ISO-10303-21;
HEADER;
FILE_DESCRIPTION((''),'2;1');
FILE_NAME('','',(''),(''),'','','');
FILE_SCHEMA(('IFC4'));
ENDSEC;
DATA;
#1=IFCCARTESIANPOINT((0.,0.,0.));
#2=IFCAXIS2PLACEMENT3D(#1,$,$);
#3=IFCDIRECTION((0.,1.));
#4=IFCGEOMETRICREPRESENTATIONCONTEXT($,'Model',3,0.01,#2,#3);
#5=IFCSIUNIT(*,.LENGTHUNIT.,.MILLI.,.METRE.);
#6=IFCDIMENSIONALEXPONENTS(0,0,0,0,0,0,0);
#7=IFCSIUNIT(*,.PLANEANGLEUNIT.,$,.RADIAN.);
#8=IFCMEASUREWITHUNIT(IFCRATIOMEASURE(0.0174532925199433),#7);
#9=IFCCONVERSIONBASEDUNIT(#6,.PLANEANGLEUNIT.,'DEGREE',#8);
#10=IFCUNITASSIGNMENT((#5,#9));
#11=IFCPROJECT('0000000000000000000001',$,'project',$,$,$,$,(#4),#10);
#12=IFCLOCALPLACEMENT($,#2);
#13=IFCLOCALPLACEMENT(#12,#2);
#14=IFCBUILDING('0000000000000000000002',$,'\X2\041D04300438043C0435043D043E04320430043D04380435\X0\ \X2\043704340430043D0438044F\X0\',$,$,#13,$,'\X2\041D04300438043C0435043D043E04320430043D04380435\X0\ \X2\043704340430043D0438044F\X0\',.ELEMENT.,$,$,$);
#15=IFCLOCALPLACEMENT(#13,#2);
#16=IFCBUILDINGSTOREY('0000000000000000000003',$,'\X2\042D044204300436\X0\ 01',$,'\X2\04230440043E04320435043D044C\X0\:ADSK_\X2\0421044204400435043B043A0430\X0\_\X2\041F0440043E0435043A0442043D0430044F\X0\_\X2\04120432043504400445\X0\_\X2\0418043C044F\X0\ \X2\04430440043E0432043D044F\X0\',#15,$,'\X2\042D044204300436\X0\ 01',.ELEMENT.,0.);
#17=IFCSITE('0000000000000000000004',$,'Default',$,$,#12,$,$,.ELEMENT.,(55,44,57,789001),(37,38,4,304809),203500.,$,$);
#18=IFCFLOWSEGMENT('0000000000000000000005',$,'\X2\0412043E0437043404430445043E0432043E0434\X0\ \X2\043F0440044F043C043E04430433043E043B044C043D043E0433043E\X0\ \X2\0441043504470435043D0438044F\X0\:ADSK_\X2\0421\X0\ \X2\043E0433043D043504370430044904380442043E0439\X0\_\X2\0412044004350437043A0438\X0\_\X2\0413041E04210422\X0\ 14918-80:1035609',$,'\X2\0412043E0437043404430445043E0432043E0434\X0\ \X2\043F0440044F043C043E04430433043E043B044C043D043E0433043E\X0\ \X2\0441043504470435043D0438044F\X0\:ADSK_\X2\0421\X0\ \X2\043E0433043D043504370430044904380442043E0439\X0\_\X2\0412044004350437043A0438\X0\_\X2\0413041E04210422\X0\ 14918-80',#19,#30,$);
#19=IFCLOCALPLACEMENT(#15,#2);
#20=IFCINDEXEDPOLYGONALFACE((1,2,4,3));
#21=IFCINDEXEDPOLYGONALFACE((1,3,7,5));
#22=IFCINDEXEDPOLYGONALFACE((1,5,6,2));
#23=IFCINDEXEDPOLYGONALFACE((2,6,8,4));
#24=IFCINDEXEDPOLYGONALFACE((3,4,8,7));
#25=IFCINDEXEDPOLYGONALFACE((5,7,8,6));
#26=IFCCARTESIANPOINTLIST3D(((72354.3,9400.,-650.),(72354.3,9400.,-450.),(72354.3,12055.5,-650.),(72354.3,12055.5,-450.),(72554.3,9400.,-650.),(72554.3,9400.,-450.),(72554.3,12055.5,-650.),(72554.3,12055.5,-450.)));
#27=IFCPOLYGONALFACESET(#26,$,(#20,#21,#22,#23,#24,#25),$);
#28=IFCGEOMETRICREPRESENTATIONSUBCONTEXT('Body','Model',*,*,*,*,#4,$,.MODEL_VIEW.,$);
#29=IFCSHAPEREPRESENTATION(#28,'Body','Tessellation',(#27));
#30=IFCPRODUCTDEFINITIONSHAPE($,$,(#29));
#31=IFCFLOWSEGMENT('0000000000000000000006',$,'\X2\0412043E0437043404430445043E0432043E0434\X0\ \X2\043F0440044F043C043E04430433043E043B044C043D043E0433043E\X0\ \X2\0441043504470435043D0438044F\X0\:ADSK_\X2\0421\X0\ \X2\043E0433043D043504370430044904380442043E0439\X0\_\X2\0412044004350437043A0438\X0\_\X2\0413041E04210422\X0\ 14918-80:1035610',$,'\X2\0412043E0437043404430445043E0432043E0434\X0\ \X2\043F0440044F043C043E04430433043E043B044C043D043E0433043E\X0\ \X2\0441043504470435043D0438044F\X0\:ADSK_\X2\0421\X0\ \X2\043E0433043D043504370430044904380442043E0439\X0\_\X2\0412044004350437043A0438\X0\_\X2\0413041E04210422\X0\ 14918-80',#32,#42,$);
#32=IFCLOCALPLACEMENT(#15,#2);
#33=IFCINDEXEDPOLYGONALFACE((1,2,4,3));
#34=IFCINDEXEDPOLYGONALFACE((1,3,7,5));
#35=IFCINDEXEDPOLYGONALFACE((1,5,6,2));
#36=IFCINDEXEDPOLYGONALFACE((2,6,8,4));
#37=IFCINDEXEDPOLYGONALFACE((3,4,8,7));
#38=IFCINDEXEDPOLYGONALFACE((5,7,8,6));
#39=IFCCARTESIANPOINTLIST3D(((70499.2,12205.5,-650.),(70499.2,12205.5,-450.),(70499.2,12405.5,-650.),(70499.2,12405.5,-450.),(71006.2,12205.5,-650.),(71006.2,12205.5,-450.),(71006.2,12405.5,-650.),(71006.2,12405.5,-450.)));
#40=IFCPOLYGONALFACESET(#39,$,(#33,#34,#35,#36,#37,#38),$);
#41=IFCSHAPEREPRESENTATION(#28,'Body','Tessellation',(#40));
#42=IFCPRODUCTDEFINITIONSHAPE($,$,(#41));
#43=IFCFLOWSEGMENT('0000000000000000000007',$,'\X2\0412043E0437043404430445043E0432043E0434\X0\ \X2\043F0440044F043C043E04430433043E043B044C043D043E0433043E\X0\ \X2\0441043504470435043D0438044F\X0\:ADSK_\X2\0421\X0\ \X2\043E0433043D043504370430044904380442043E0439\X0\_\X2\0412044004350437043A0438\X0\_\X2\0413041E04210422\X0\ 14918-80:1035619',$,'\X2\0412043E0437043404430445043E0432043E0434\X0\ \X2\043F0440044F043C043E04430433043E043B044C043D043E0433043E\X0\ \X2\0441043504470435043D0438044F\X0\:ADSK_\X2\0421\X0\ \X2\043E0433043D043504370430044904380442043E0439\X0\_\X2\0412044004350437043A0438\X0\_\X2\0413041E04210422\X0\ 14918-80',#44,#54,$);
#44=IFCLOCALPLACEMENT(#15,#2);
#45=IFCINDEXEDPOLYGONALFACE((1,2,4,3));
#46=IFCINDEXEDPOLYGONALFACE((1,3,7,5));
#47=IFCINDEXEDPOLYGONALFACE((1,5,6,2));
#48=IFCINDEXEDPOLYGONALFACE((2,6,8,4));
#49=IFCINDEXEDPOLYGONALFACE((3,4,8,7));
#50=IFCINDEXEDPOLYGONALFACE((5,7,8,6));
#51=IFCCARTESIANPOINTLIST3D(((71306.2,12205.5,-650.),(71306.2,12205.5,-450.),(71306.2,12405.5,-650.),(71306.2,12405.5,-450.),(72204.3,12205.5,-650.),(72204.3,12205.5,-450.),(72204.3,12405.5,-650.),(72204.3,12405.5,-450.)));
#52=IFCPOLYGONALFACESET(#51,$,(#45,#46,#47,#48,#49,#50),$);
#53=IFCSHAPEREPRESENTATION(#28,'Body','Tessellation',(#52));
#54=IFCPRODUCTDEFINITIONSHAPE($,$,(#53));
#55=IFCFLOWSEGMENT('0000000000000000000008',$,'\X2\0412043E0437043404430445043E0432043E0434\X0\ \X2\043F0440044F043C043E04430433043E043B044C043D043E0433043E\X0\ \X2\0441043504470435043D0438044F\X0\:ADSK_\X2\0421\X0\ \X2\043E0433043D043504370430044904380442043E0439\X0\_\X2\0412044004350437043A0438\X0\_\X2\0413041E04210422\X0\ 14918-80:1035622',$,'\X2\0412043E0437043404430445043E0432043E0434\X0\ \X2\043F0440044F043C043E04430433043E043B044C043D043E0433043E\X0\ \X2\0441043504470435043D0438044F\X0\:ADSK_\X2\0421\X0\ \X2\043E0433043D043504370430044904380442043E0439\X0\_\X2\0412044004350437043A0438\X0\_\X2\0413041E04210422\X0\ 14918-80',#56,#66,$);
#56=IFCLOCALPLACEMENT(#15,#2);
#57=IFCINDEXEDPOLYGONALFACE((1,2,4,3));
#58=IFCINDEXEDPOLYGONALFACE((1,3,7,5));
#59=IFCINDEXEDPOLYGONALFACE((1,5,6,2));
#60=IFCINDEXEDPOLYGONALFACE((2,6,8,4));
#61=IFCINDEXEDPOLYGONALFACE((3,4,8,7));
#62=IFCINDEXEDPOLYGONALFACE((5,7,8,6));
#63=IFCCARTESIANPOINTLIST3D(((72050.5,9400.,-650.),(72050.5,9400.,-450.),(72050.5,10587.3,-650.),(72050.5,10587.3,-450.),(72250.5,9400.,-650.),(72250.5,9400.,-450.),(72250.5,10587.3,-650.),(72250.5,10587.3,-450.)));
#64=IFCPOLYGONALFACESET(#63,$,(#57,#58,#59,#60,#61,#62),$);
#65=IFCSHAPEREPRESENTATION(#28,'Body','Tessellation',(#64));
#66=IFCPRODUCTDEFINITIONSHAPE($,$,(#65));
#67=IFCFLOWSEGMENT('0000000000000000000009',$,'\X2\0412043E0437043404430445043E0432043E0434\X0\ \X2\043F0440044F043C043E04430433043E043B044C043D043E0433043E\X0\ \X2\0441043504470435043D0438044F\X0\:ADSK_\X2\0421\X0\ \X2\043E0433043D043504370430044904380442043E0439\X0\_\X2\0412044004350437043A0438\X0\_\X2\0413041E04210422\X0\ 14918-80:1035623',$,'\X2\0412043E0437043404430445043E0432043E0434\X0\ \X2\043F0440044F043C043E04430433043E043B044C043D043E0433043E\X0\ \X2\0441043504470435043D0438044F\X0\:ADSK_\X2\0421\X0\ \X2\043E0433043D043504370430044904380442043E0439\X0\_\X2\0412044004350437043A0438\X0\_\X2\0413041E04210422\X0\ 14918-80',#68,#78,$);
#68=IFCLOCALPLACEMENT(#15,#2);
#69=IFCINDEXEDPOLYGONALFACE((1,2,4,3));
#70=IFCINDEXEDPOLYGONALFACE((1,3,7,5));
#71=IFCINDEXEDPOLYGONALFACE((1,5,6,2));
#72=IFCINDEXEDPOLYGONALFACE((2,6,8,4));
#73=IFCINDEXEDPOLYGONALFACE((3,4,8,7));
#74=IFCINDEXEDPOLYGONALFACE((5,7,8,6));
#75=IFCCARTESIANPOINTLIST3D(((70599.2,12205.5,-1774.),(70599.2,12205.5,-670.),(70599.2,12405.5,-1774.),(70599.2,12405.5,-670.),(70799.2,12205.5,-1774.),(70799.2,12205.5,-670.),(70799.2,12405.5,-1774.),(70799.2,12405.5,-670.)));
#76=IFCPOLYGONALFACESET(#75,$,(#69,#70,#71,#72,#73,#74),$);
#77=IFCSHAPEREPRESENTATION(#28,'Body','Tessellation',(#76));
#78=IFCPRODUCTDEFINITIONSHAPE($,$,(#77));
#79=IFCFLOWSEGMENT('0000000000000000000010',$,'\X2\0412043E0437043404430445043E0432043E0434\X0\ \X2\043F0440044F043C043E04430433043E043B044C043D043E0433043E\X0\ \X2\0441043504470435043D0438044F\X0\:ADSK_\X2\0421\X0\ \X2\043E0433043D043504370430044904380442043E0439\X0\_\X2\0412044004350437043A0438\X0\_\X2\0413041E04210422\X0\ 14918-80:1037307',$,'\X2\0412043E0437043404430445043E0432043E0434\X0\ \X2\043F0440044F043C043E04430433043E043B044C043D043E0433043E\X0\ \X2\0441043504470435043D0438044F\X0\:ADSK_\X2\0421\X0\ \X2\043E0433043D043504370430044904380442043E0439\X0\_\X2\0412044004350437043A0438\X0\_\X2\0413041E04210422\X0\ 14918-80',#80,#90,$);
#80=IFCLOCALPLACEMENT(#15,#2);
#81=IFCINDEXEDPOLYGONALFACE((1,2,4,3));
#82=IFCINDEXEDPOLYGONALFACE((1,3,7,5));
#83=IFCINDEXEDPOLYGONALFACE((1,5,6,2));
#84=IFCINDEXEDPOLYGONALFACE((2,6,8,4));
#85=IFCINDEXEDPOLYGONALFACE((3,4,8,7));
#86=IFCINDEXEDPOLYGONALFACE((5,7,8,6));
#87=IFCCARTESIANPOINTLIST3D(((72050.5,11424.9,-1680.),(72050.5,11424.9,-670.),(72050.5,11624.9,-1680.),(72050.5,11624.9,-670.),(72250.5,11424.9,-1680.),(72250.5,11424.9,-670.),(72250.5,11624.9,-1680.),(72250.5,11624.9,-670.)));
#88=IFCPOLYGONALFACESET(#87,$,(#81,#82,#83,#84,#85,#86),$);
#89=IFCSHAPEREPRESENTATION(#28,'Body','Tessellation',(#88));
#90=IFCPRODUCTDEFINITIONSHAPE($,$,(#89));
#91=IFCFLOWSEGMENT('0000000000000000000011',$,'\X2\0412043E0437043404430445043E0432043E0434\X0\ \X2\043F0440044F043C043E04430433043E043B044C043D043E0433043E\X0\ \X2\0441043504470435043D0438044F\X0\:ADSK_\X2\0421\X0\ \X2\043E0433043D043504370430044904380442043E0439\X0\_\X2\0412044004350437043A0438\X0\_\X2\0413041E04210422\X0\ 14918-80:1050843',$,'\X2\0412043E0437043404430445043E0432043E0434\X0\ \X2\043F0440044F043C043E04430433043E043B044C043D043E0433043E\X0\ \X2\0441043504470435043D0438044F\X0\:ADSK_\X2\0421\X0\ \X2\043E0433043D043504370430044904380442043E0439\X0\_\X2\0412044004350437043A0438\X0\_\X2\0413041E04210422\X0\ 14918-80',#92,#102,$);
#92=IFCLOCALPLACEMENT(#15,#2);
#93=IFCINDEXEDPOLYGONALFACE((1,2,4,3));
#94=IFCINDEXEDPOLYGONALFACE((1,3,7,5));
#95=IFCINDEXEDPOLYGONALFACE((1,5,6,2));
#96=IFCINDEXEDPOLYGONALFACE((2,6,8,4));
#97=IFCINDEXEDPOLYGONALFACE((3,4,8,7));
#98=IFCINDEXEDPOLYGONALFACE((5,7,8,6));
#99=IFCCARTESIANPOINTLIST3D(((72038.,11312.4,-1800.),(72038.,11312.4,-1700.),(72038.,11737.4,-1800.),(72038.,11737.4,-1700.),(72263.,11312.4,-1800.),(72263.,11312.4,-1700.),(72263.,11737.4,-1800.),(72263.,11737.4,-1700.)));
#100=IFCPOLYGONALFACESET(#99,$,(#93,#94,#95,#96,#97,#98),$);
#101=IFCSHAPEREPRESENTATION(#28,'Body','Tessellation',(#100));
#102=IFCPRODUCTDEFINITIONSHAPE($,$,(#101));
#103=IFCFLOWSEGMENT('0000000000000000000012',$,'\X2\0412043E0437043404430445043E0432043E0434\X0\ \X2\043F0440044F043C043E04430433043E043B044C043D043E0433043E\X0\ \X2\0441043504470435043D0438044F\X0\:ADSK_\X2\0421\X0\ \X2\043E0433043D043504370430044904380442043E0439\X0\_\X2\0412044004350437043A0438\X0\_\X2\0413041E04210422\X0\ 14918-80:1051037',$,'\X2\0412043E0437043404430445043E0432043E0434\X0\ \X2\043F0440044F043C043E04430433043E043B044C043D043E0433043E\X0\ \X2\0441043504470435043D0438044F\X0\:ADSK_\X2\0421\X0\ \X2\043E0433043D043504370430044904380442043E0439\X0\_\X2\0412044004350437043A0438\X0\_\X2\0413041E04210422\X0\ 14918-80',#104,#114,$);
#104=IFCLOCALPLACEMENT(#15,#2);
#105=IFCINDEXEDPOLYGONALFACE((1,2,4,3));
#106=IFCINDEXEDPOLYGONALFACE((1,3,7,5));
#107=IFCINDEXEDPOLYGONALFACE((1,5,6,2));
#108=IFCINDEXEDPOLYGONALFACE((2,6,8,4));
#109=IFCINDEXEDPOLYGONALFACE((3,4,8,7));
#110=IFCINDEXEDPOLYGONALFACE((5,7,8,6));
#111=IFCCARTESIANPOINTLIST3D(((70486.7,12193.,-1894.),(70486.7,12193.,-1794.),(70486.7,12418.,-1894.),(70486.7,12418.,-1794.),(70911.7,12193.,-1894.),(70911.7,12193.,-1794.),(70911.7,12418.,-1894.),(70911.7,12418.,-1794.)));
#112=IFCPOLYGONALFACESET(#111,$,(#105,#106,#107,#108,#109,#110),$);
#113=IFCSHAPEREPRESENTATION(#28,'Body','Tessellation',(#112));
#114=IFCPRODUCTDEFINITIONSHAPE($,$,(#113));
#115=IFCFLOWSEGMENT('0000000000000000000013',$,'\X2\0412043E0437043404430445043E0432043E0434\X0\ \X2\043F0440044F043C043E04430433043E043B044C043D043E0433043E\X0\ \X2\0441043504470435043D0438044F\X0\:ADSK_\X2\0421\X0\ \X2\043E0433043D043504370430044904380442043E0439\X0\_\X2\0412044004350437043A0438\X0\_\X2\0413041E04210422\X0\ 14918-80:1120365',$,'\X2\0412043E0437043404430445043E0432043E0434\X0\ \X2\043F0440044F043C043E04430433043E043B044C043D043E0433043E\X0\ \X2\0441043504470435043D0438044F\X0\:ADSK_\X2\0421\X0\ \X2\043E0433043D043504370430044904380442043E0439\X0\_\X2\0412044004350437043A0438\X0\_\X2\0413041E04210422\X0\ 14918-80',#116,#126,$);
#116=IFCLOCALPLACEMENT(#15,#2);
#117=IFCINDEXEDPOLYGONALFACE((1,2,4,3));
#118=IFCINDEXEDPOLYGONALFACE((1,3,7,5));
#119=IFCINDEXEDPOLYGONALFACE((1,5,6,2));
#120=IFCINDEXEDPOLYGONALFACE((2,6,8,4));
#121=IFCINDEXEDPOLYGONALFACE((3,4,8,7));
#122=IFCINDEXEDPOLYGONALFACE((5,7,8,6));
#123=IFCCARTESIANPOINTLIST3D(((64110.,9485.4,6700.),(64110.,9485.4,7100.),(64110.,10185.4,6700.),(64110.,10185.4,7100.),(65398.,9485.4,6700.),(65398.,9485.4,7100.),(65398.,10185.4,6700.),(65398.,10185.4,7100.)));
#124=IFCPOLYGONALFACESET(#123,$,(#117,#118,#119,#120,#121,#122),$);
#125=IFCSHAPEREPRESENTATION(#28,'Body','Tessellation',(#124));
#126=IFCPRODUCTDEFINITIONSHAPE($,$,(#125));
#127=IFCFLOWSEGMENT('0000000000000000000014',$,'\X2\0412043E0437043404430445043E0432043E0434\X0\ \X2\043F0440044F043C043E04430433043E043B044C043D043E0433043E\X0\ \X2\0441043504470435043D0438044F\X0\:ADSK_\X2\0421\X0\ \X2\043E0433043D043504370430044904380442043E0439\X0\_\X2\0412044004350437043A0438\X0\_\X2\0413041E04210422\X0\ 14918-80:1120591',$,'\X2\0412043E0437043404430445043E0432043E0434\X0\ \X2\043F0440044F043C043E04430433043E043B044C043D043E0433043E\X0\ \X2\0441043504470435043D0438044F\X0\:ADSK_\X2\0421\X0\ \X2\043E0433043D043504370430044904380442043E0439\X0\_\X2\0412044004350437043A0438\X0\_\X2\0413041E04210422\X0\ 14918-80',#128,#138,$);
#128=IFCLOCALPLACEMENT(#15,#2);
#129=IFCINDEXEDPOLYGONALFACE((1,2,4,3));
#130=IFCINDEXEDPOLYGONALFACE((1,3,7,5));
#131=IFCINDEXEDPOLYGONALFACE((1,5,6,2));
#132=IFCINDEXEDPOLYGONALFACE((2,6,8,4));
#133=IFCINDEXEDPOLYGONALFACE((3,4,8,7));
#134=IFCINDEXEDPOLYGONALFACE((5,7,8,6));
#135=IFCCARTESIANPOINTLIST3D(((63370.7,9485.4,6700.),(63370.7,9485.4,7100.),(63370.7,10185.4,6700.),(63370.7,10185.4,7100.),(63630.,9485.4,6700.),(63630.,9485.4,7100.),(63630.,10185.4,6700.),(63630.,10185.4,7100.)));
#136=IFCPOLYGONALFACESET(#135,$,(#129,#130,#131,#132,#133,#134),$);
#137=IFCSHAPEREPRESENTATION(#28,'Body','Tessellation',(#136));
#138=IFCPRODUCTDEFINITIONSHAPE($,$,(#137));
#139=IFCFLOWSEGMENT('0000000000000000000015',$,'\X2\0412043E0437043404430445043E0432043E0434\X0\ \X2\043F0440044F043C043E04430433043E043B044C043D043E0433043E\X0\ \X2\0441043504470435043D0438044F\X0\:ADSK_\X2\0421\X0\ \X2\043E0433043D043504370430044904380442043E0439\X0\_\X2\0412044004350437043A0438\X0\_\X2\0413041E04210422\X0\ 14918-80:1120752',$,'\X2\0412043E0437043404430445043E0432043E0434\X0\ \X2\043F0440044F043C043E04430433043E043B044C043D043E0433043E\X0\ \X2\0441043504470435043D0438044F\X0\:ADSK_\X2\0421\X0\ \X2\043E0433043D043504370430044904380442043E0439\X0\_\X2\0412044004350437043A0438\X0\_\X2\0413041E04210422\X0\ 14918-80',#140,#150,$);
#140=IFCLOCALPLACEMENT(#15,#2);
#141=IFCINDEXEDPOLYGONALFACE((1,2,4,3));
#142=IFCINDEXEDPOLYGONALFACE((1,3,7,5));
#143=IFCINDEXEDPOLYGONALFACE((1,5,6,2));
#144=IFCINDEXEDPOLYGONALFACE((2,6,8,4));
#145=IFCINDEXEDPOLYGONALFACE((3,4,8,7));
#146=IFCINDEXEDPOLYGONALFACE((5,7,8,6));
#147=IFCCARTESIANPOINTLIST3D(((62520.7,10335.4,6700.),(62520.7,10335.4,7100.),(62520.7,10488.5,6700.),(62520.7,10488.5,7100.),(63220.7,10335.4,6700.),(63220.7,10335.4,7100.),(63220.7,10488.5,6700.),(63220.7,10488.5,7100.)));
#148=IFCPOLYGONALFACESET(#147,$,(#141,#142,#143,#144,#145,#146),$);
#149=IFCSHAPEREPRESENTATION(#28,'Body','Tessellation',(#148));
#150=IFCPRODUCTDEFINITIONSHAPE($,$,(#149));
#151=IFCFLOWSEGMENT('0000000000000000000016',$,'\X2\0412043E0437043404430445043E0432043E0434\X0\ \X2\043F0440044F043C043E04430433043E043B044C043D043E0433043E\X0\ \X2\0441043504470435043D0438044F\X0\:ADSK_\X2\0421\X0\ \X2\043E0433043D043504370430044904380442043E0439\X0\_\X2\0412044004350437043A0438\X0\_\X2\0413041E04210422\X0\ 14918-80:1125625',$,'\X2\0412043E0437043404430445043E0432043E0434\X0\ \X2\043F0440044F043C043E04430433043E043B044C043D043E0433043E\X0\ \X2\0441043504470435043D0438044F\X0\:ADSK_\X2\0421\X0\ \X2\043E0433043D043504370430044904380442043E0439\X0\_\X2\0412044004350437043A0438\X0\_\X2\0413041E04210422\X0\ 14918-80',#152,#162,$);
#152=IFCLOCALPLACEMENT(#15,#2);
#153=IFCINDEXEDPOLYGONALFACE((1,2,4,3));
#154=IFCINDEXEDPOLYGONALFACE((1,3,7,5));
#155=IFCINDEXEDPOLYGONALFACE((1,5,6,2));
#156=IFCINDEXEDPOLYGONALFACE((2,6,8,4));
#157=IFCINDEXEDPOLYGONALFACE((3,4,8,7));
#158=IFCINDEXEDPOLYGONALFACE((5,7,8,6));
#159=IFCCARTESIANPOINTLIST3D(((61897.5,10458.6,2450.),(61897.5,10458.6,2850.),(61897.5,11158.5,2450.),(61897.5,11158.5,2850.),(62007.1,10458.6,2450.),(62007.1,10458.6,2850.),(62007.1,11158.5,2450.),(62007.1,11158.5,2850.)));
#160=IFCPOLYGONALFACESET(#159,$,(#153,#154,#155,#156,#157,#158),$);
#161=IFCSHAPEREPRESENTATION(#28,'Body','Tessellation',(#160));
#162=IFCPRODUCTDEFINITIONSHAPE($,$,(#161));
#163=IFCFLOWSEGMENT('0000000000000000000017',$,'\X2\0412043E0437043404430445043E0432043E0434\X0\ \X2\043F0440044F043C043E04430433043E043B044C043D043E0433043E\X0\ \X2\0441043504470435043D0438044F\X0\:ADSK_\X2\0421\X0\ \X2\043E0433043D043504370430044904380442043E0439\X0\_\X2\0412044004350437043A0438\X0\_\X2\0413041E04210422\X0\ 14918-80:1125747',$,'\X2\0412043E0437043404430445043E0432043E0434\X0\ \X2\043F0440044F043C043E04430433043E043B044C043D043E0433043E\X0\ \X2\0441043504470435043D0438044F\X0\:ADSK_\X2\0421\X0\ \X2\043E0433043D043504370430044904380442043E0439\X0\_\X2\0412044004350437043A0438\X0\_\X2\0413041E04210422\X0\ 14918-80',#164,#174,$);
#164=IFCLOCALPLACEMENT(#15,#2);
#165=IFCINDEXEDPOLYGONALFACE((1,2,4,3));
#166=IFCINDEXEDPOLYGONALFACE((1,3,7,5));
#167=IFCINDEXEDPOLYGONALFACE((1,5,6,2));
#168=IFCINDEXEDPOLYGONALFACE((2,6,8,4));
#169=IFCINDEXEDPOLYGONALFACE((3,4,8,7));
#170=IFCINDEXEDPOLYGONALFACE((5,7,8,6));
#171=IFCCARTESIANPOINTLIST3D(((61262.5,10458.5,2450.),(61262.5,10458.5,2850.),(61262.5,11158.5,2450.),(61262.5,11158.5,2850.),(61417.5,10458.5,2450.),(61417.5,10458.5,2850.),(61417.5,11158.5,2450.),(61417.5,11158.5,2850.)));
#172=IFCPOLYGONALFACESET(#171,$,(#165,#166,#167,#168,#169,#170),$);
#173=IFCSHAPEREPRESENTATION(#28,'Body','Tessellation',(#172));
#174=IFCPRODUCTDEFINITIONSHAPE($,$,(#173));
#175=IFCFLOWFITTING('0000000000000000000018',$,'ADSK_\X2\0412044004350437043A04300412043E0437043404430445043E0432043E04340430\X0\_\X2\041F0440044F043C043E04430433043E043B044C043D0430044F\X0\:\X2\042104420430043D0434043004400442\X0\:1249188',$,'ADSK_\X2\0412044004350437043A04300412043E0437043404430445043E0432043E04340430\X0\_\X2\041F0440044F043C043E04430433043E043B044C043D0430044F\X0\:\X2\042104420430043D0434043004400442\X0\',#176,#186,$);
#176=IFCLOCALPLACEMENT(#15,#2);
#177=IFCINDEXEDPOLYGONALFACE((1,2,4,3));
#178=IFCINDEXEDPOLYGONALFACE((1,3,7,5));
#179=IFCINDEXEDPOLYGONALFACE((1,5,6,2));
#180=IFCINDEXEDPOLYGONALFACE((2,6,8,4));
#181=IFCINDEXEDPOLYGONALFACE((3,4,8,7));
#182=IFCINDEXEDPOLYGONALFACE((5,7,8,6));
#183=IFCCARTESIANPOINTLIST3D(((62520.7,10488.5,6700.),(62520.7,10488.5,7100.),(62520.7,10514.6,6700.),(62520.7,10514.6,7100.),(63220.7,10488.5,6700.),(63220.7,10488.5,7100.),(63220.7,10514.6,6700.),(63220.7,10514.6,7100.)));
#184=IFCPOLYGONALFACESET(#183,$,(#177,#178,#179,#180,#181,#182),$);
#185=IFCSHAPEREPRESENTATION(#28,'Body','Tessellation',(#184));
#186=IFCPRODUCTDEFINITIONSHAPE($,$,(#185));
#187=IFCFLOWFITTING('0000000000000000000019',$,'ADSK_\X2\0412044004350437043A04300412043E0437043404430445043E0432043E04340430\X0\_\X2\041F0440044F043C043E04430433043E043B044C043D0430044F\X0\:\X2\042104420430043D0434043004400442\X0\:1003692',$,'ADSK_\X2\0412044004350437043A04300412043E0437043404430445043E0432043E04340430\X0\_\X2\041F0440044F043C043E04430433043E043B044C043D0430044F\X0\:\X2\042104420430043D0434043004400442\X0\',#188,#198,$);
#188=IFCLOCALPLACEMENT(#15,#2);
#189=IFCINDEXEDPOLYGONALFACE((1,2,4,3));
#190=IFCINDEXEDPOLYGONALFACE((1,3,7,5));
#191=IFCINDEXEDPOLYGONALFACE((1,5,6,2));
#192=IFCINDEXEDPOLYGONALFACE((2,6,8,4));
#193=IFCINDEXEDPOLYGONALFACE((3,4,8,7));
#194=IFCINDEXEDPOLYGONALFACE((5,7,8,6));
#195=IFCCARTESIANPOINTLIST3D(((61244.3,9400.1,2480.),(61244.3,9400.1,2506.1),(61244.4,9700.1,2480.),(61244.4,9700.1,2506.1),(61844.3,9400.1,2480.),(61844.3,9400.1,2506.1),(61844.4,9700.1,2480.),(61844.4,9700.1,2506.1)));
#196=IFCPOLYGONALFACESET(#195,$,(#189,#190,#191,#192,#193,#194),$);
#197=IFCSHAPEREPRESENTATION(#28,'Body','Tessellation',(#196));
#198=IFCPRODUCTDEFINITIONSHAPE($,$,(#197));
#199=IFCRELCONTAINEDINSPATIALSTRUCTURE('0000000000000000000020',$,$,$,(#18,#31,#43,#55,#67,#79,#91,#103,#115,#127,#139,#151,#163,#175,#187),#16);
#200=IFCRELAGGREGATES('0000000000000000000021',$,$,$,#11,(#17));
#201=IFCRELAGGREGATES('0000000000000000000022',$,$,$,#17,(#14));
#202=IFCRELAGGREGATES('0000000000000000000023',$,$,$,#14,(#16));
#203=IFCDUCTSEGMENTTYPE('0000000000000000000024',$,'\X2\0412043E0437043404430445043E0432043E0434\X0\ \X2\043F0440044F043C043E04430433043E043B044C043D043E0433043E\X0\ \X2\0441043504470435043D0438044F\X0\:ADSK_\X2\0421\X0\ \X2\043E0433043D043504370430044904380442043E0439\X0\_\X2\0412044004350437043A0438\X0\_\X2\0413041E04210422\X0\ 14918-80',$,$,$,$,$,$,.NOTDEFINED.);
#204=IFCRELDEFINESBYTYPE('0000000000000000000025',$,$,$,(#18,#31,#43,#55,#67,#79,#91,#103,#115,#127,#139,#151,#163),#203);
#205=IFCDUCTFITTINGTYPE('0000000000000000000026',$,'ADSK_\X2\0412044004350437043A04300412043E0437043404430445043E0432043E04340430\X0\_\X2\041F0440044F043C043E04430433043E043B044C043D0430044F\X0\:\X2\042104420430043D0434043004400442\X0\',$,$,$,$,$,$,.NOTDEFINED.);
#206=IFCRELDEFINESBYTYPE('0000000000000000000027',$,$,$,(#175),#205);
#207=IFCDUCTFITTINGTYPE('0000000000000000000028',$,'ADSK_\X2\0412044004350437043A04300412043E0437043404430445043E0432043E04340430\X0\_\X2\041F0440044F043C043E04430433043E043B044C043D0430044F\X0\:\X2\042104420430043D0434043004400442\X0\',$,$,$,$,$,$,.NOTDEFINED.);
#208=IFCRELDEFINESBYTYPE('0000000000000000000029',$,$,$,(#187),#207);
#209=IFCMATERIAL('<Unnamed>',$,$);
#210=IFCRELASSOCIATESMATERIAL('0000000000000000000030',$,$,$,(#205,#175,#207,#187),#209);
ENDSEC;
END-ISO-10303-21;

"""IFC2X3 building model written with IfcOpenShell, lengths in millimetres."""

from ifc_helpers import new_model, entity, si_unit, converted_unit, direction, frame, origin, origin_2d_with_axis, place, context, subcontext, project, spatial, rectangle, extrude, source, transform, mapped, material, type_object, type_shapes, element, save


model = new_model("IFC2X3")

# Units and contexts
model_context = context("Model", 3, precision=0.01, world=origin(), true_north=direction((0.0, 1.0)))
body_context = subcontext(model_context, "Body", "Model", "MODEL_VIEW")
ifc_project = project(units=[si_unit("LENGTHUNIT", "METRE", prefix="MILLI"), converted_unit("PLANEANGLEUNIT", "DEGREE", entity("IfcRatioMeasure", 0.0174532925199433), si_unit("PLANEANGLEUNIT", "RADIAN"), dimensions=[0, 0, 0, 0, 0, 0, 0])], contexts=[model_context])

# Site, building, storey
site_placement = place(None, origin())
site = spatial("IfcSite", under=ifc_project, at=site_placement, Name="Default", CompositionType="ELEMENT", RefLatitude=(55, 44, 57, 789001), RefLongitude=(37, 38, 4, 304809), RefElevation=203500.0)
building_placement = place(site_placement, origin())
building = spatial("IfcBuilding", under=site, at=building_placement, Name="Наименование здания", LongName="Наименование здания", CompositionType="ELEMENT")
storey_placement = place(building_placement, origin())
storey = spatial("IfcBuildingStorey", under=building, at=storey_placement, Name="Этаж 01", ObjectType="Уровень:ADSK_Стрелка_Проектная_Вверх_Имя уровня", LongName="Этаж 01", CompositionType="ELEMENT", Elevation=0.0)

# Flow segments
duct_segment_type = type_object("IfcDuctSegmentType", Name="Воздуховод прямоугольного сечения:ADSK_С огнезащитой_Врезки_ГОСТ 14918-80", PredefinedType="NOTDEFINED")
flow_segment_1_placement = place(storey_placement, frame((72354.3, 9400.0, -650.0)))
element("IfcFlowSegment", 1, at=flow_segment_1_placement, inside=storey, type_object=duct_segment_type, Name="Воздуховод прямоугольного сечения:ADSK_С огнезащитой_Врезки_ГОСТ 14918-80:1035609", ObjectType="Воздуховод прямоугольного сечения:ADSK_С огнезащитой_Врезки_ГОСТ 14918-80", context=body_context, shape_type="SweptSolid", body=[
    extrude(rectangle(XDim=2655.5, YDim=200.0, at=origin_2d_with_axis()), frame((100.0, 1327.8, 0.0), z_axis=(0.0, 0.0, 1.0), x_axis=(0.0, -1.0, 0.0)), (0.0, 0.0, 1.0), 200.0),
])
flow_segment_2_placement = place(storey_placement, frame((70499.2, 12205.5, -650.0)))
element("IfcFlowSegment", 2, at=flow_segment_2_placement, inside=storey, type_object=duct_segment_type, Name="Воздуховод прямоугольного сечения:ADSK_С огнезащитой_Врезки_ГОСТ 14918-80:1035610", ObjectType="Воздуховод прямоугольного сечения:ADSK_С огнезащитой_Врезки_ГОСТ 14918-80", context=body_context, shape_type="SweptSolid", body=[
    extrude(rectangle(XDim=507.0, YDim=200.0, at=origin_2d_with_axis()), frame((253.5, 100.0, 0.0), z_axis=(0.0, 0.0, 1.0), x_axis=(-1.0, 0.0, 0.0)), (0.0, 0.0, 1.0), 200.0),
])
flow_segment_3_placement = place(storey_placement, frame((71306.2, 12205.5, -650.0)))
element("IfcFlowSegment", 3, at=flow_segment_3_placement, inside=storey, type_object=duct_segment_type, Name="Воздуховод прямоугольного сечения:ADSK_С огнезащитой_Врезки_ГОСТ 14918-80:1035619", ObjectType="Воздуховод прямоугольного сечения:ADSK_С огнезащитой_Врезки_ГОСТ 14918-80", context=body_context, shape_type="SweptSolid", body=[
    extrude(rectangle(XDim=898.1, YDim=200.0, at=origin_2d_with_axis()), frame((449.0, 100.0, 0.0), z_axis=(0.0, 0.0, 1.0), x_axis=(-1.0, 0.0, 0.0)), (0.0, 0.0, 1.0), 200.0),
])
flow_segment_4_placement = place(storey_placement, frame((72050.5, 9400.0, -650.0)))
element("IfcFlowSegment", 4, at=flow_segment_4_placement, inside=storey, type_object=duct_segment_type, Name="Воздуховод прямоугольного сечения:ADSK_С огнезащитой_Врезки_ГОСТ 14918-80:1035622", ObjectType="Воздуховод прямоугольного сечения:ADSK_С огнезащитой_Врезки_ГОСТ 14918-80", context=body_context, shape_type="SweptSolid", body=[
    extrude(rectangle(XDim=1187.3, YDim=200.0, at=origin_2d_with_axis()), frame((100.0, 593.6, 0.0), z_axis=(0.0, 0.0, 1.0), x_axis=(0.0, 1.0, 0.0)), (0.0, 0.0, 1.0), 200.0),
])
flow_segment_5_placement = place(storey_placement, frame((70599.2, 12205.5, -1774.0)))
element("IfcFlowSegment", 5, at=flow_segment_5_placement, inside=storey, type_object=duct_segment_type, Name="Воздуховод прямоугольного сечения:ADSK_С огнезащитой_Врезки_ГОСТ 14918-80:1035623", ObjectType="Воздуховод прямоугольного сечения:ADSK_С огнезащитой_Врезки_ГОСТ 14918-80", context=body_context, shape_type="SweptSolid", body=[
    extrude(rectangle(XDim=200.0, YDim=200.0, at=origin_2d_with_axis()), frame((100.0, 100.0, 0.0), z_axis=(0.0, 0.0, 1.0), x_axis=(0.0, 1.0, 0.0)), (0.0, 0.0, 1.0), 1104.0),
])
flow_segment_6_placement = place(storey_placement, frame((72050.5, 11424.9, -1680.0)))
element("IfcFlowSegment", 6, at=flow_segment_6_placement, inside=storey, type_object=duct_segment_type, Name="Воздуховод прямоугольного сечения:ADSK_С огнезащитой_Врезки_ГОСТ 14918-80:1037307", ObjectType="Воздуховод прямоугольного сечения:ADSK_С огнезащитой_Врезки_ГОСТ 14918-80", context=body_context, shape_type="SweptSolid", body=[
    extrude(rectangle(XDim=200.0, YDim=200.0, at=origin_2d_with_axis()), frame((100.0, 100.0, 0.0)), (0.0, 0.0, 1.0), 1010.0),
])
flow_segment_7_placement = place(storey_placement, frame((72038.0, 11312.4, -1800.0)))
element("IfcFlowSegment", 7, at=flow_segment_7_placement, inside=storey, type_object=duct_segment_type, Name="Воздуховод прямоугольного сечения:ADSK_С огнезащитой_Врезки_ГОСТ 14918-80:1050843", ObjectType="Воздуховод прямоугольного сечения:ADSK_С огнезащитой_Врезки_ГОСТ 14918-80", context=body_context, shape_type="SweptSolid", body=[
    extrude(rectangle(XDim=425.0, YDim=225.0, at=origin_2d_with_axis()), frame((112.5, 212.5, 0.0), z_axis=(0.0, 0.0, 1.0), x_axis=(0.0, -1.0, 0.0)), (0.0, 0.0, 1.0), 100.0),
])
flow_segment_8_placement = place(storey_placement, frame((70486.7, 12193.0, -1894.0)))
element("IfcFlowSegment", 8, at=flow_segment_8_placement, inside=storey, type_object=duct_segment_type, Name="Воздуховод прямоугольного сечения:ADSK_С огнезащитой_Врезки_ГОСТ 14918-80:1051037", ObjectType="Воздуховод прямоугольного сечения:ADSK_С огнезащитой_Врезки_ГОСТ 14918-80", context=body_context, shape_type="SweptSolid", body=[
    extrude(rectangle(XDim=425.0, YDim=225.0, at=origin_2d_with_axis()), frame((212.5, 112.5, 0.0)), (0.0, 0.0, 1.0), 100.0),
])
flow_segment_9_placement = place(storey_placement, frame((64110.0, 9485.4, 6700.0)))
element("IfcFlowSegment", 9, at=flow_segment_9_placement, inside=storey, type_object=duct_segment_type, Name="Воздуховод прямоугольного сечения:ADSK_С огнезащитой_Врезки_ГОСТ 14918-80:1120365", ObjectType="Воздуховод прямоугольного сечения:ADSK_С огнезащитой_Врезки_ГОСТ 14918-80", context=body_context, shape_type="SweptSolid", body=[
    extrude(rectangle(XDim=1288.0, YDim=700.0, at=origin_2d_with_axis()), frame((644.0, 350.0, 0.0)), (0.0, 0.0, 1.0), 400.0),
])
flow_segment_10_placement = place(storey_placement, frame((63370.7, 9485.4, 6700.0)))
element("IfcFlowSegment", 10, at=flow_segment_10_placement, inside=storey, type_object=duct_segment_type, Name="Воздуховод прямоугольного сечения:ADSK_С огнезащитой_Врезки_ГОСТ 14918-80:1120591", ObjectType="Воздуховод прямоугольного сечения:ADSK_С огнезащитой_Врезки_ГОСТ 14918-80", context=body_context, shape_type="SweptSolid", body=[
    extrude(rectangle(XDim=259.3, YDim=700.0, at=origin_2d_with_axis()), frame((129.7, 350.0, 0.0), z_axis=(0.0, 0.0, 1.0), x_axis=(-1.0, 0.0, 0.0)), (0.0, 0.0, 1.0), 400.0),
])
flow_segment_11_placement = place(storey_placement, frame((62520.7, 10335.4, 6700.0)))
element("IfcFlowSegment", 11, at=flow_segment_11_placement, inside=storey, type_object=duct_segment_type, Name="Воздуховод прямоугольного сечения:ADSK_С огнезащитой_Врезки_ГОСТ 14918-80:1120752", ObjectType="Воздуховод прямоугольного сечения:ADSK_С огнезащитой_Врезки_ГОСТ 14918-80", context=body_context, shape_type="SweptSolid", body=[
    extrude(rectangle(XDim=153.1, YDim=700.0, at=origin_2d_with_axis()), frame((350.0, 76.6, 0.0), z_axis=(0.0, 0.0, 1.0), x_axis=(0.0, 1.0, 0.0)), (0.0, 0.0, 1.0), 400.0),
])
flow_segment_12_placement = place(storey_placement, frame((61897.5, 10458.5, 2450.0)))
element("IfcFlowSegment", 12, at=flow_segment_12_placement, inside=storey, type_object=duct_segment_type, Name="Воздуховод прямоугольного сечения:ADSK_С огнезащитой_Врезки_ГОСТ 14918-80:1125625", ObjectType="Воздуховод прямоугольного сечения:ADSK_С огнезащитой_Врезки_ГОСТ 14918-80", context=body_context, shape_type="SweptSolid", body=[
    extrude(rectangle(XDim=109.6, YDim=700.0, at=origin_2d_with_axis()), frame((54.8, 350.0, 0.0)), (0.0, 0.0, 1.0), 400.0),
])
flow_segment_13_placement = place(storey_placement, frame((61262.5, 10458.5, 2450.0)))
element("IfcFlowSegment", 13, at=flow_segment_13_placement, inside=storey, type_object=duct_segment_type, Name="Воздуховод прямоугольного сечения:ADSK_С огнезащитой_Врезки_ГОСТ 14918-80:1125747", ObjectType="Воздуховод прямоугольного сечения:ADSK_С огнезащитой_Врезки_ГОСТ 14918-80", context=body_context, shape_type="SweptSolid", body=[
    extrude(rectangle(XDim=155.0, YDim=700.0, at=origin_2d_with_axis()), frame((77.5, 350.0, 0.0), z_axis=(0.0, 0.0, 1.0), x_axis=(1.0, 0.000074, 0.0)), (0.0, 0.0, 1.0), 400.0),
])

# Flow fittings
ifc_material_1 = material(Name="<Unnamed>")
duct_fitting_type_1 = type_object("IfcDuctFittingType", Name="ADSK_ВрезкаВоздуховода_Прямоугольная:Стандарт", PredefinedType="NOTDEFINED", material=ifc_material_1)
shared_shape_1 = source(origin(), body_context, "Body", "SweptSolid", [
    extrude(rectangle(XDim=26.1, YDim=400.0, at=origin_2d_with_axis()), frame((7.0, 0.0, -350.0)), (0.0, 0.0, 1.0), 700.0),
])
type_shapes(duct_fitting_type_1, [shared_shape_1])
flow_fitting_1_placement = place(storey_placement, frame((62870.7, 10508.5, 6900.0), z_axis=(-1.0, 0.0, 0.0), x_axis=(0.0, -1.0, 0.0)))
element("IfcFlowFitting", 14, at=flow_fitting_1_placement, inside=storey, type_object=duct_fitting_type_1, material=ifc_material_1, Name="ADSK_ВрезкаВоздуховода_Прямоугольная:Стандарт:1249188", ObjectType="ADSK_ВрезкаВоздуховода_Прямоугольная:Стандарт", context=body_context, shape_type="MappedRepresentation", body=[
    mapped(shared_shape_1, transform((0.0, 0.0, 0.0), scale=1.0)),
])
duct_fitting_type_2 = type_object("IfcDuctFittingType", Name="ADSK_ВрезкаВоздуховода_Прямоугольная:Стандарт", PredefinedType="NOTDEFINED", material=ifc_material_1)
shared_shape_2 = source(origin(), body_context, "Body", "SweptSolid", [
    extrude(rectangle(XDim=26.1, YDim=600.0, at=origin_2d_with_axis()), frame((7.0, 0.0, -150.0)), (0.0, 0.0, 1.0), 300.0),
])
type_shapes(duct_fitting_type_2, [shared_shape_2])
flow_fitting_2_placement = place(storey_placement, frame((61544.3, 9550.1, 2500.0), z_axis=(0.000005, 1.0, 0.0), x_axis=(0.0, 0.0, -1.0)))
element("IfcFlowFitting", 15, at=flow_fitting_2_placement, inside=storey, type_object=duct_fitting_type_2, material=ifc_material_1, Name="ADSK_ВрезкаВоздуховода_Прямоугольная:Стандарт:1003692", ObjectType="ADSK_ВрезкаВоздуховода_Прямоугольная:Стандарт", context=body_context, shape_type="MappedRepresentation", body=[
    mapped(shared_shape_2, transform((0.0, 0.0, 0.0), scale=1.0)),
])

save(model, "model.ifc")
